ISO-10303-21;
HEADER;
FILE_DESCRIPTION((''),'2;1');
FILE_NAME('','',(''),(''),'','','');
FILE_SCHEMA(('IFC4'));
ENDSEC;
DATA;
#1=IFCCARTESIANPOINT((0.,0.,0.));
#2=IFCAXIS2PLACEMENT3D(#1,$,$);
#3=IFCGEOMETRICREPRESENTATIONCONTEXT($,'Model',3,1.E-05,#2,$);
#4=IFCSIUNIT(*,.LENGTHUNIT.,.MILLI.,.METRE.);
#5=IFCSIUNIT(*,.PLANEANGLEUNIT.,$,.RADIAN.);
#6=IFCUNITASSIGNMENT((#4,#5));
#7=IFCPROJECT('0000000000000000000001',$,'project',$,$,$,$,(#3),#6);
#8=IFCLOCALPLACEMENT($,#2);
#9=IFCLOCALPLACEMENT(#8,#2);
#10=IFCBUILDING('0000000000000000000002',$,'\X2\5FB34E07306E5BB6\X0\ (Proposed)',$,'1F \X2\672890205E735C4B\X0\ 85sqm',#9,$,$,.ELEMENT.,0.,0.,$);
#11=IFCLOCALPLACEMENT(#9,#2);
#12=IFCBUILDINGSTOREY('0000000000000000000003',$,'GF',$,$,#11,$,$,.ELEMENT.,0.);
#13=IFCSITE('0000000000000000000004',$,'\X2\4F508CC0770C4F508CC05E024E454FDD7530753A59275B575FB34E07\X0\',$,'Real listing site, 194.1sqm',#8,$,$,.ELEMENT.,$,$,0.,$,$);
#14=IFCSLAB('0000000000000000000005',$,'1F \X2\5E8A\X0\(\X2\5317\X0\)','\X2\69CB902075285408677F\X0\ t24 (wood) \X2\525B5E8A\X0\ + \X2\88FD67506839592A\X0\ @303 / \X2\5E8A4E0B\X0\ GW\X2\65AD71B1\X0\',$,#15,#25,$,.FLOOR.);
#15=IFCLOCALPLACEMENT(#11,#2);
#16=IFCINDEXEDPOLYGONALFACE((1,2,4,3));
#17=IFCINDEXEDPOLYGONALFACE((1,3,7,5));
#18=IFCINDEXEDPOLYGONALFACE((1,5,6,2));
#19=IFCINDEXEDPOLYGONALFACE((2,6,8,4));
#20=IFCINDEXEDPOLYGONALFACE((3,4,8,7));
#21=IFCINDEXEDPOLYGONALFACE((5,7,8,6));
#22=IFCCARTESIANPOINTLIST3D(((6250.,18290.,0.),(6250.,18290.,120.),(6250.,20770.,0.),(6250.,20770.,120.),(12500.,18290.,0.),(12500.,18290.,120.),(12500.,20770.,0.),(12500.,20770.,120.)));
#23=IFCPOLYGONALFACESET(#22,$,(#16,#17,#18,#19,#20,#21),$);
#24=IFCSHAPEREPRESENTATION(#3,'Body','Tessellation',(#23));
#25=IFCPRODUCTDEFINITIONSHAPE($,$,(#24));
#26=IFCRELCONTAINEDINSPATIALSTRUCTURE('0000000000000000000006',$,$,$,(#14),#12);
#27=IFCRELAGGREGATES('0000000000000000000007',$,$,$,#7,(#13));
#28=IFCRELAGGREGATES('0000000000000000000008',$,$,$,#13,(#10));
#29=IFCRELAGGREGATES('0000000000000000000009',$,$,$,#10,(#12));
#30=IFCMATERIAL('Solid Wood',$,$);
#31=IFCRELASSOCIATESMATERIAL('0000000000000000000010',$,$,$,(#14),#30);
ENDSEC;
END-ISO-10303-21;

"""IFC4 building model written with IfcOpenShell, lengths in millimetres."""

from ifc_helpers import new_model, si_unit, frame, frame_2d, origin, place, context, project, spatial, rectangle, extrude, material, element, save


model = new_model("IFC4")

# Units and contexts
model_context = context("Model", 3, precision=1e-05, world=origin())
ifc_project = project(units=[si_unit("LENGTHUNIT", "METRE", prefix="MILLI"), si_unit("PLANEANGLEUNIT", "RADIAN")], contexts=[model_context])

# Site, building, storey
site_placement = place(None, origin())
site = spatial("IfcSite", under=ifc_project, at=site_placement, Name="佐賀県佐賀市久保田町大字徳万", ObjectType="Real listing site, 194.1sqm", CompositionType="ELEMENT", RefElevation=0.0)
building_placement = place(site_placement, origin())
building = spatial("IfcBuilding", under=site, at=building_placement, Name="徳万の家 (Proposed)", ObjectType="1F 木造平屋 85sqm", CompositionType="ELEMENT", ElevationOfRefHeight=0.0, ElevationOfTerrain=0.0)
storey_placement = place(building_placement, origin())
storey = spatial("IfcBuildingStorey", under=building, at=storey_placement, Name="GF", CompositionType="ELEMENT", Elevation=0.0)

# Slab
ifc_material_1 = material(Name="Solid Wood")
slab_1_placement = place(storey_placement, frame((3125.0, 9145.0, 0.0)))
element("IfcSlab", 1, at=slab_1_placement, inside=storey, material=ifc_material_1, Name="1F 床(北)", Description="構造用合板 t24 (wood) 剛床 + 製材根太 @303 / 床下 GW断熱", PredefinedType="FLOOR", context=model_context, shape_type="SweptSolid", body=[
    extrude(rectangle(XDim=6250.0, YDim=2480.0, at=frame_2d((3125.0, 1240.0))), frame((3125.0, 9145.0, 0.0)), (0.0, 0.0, 1.0), 120.0),
])

save(model, "model.ifc")
